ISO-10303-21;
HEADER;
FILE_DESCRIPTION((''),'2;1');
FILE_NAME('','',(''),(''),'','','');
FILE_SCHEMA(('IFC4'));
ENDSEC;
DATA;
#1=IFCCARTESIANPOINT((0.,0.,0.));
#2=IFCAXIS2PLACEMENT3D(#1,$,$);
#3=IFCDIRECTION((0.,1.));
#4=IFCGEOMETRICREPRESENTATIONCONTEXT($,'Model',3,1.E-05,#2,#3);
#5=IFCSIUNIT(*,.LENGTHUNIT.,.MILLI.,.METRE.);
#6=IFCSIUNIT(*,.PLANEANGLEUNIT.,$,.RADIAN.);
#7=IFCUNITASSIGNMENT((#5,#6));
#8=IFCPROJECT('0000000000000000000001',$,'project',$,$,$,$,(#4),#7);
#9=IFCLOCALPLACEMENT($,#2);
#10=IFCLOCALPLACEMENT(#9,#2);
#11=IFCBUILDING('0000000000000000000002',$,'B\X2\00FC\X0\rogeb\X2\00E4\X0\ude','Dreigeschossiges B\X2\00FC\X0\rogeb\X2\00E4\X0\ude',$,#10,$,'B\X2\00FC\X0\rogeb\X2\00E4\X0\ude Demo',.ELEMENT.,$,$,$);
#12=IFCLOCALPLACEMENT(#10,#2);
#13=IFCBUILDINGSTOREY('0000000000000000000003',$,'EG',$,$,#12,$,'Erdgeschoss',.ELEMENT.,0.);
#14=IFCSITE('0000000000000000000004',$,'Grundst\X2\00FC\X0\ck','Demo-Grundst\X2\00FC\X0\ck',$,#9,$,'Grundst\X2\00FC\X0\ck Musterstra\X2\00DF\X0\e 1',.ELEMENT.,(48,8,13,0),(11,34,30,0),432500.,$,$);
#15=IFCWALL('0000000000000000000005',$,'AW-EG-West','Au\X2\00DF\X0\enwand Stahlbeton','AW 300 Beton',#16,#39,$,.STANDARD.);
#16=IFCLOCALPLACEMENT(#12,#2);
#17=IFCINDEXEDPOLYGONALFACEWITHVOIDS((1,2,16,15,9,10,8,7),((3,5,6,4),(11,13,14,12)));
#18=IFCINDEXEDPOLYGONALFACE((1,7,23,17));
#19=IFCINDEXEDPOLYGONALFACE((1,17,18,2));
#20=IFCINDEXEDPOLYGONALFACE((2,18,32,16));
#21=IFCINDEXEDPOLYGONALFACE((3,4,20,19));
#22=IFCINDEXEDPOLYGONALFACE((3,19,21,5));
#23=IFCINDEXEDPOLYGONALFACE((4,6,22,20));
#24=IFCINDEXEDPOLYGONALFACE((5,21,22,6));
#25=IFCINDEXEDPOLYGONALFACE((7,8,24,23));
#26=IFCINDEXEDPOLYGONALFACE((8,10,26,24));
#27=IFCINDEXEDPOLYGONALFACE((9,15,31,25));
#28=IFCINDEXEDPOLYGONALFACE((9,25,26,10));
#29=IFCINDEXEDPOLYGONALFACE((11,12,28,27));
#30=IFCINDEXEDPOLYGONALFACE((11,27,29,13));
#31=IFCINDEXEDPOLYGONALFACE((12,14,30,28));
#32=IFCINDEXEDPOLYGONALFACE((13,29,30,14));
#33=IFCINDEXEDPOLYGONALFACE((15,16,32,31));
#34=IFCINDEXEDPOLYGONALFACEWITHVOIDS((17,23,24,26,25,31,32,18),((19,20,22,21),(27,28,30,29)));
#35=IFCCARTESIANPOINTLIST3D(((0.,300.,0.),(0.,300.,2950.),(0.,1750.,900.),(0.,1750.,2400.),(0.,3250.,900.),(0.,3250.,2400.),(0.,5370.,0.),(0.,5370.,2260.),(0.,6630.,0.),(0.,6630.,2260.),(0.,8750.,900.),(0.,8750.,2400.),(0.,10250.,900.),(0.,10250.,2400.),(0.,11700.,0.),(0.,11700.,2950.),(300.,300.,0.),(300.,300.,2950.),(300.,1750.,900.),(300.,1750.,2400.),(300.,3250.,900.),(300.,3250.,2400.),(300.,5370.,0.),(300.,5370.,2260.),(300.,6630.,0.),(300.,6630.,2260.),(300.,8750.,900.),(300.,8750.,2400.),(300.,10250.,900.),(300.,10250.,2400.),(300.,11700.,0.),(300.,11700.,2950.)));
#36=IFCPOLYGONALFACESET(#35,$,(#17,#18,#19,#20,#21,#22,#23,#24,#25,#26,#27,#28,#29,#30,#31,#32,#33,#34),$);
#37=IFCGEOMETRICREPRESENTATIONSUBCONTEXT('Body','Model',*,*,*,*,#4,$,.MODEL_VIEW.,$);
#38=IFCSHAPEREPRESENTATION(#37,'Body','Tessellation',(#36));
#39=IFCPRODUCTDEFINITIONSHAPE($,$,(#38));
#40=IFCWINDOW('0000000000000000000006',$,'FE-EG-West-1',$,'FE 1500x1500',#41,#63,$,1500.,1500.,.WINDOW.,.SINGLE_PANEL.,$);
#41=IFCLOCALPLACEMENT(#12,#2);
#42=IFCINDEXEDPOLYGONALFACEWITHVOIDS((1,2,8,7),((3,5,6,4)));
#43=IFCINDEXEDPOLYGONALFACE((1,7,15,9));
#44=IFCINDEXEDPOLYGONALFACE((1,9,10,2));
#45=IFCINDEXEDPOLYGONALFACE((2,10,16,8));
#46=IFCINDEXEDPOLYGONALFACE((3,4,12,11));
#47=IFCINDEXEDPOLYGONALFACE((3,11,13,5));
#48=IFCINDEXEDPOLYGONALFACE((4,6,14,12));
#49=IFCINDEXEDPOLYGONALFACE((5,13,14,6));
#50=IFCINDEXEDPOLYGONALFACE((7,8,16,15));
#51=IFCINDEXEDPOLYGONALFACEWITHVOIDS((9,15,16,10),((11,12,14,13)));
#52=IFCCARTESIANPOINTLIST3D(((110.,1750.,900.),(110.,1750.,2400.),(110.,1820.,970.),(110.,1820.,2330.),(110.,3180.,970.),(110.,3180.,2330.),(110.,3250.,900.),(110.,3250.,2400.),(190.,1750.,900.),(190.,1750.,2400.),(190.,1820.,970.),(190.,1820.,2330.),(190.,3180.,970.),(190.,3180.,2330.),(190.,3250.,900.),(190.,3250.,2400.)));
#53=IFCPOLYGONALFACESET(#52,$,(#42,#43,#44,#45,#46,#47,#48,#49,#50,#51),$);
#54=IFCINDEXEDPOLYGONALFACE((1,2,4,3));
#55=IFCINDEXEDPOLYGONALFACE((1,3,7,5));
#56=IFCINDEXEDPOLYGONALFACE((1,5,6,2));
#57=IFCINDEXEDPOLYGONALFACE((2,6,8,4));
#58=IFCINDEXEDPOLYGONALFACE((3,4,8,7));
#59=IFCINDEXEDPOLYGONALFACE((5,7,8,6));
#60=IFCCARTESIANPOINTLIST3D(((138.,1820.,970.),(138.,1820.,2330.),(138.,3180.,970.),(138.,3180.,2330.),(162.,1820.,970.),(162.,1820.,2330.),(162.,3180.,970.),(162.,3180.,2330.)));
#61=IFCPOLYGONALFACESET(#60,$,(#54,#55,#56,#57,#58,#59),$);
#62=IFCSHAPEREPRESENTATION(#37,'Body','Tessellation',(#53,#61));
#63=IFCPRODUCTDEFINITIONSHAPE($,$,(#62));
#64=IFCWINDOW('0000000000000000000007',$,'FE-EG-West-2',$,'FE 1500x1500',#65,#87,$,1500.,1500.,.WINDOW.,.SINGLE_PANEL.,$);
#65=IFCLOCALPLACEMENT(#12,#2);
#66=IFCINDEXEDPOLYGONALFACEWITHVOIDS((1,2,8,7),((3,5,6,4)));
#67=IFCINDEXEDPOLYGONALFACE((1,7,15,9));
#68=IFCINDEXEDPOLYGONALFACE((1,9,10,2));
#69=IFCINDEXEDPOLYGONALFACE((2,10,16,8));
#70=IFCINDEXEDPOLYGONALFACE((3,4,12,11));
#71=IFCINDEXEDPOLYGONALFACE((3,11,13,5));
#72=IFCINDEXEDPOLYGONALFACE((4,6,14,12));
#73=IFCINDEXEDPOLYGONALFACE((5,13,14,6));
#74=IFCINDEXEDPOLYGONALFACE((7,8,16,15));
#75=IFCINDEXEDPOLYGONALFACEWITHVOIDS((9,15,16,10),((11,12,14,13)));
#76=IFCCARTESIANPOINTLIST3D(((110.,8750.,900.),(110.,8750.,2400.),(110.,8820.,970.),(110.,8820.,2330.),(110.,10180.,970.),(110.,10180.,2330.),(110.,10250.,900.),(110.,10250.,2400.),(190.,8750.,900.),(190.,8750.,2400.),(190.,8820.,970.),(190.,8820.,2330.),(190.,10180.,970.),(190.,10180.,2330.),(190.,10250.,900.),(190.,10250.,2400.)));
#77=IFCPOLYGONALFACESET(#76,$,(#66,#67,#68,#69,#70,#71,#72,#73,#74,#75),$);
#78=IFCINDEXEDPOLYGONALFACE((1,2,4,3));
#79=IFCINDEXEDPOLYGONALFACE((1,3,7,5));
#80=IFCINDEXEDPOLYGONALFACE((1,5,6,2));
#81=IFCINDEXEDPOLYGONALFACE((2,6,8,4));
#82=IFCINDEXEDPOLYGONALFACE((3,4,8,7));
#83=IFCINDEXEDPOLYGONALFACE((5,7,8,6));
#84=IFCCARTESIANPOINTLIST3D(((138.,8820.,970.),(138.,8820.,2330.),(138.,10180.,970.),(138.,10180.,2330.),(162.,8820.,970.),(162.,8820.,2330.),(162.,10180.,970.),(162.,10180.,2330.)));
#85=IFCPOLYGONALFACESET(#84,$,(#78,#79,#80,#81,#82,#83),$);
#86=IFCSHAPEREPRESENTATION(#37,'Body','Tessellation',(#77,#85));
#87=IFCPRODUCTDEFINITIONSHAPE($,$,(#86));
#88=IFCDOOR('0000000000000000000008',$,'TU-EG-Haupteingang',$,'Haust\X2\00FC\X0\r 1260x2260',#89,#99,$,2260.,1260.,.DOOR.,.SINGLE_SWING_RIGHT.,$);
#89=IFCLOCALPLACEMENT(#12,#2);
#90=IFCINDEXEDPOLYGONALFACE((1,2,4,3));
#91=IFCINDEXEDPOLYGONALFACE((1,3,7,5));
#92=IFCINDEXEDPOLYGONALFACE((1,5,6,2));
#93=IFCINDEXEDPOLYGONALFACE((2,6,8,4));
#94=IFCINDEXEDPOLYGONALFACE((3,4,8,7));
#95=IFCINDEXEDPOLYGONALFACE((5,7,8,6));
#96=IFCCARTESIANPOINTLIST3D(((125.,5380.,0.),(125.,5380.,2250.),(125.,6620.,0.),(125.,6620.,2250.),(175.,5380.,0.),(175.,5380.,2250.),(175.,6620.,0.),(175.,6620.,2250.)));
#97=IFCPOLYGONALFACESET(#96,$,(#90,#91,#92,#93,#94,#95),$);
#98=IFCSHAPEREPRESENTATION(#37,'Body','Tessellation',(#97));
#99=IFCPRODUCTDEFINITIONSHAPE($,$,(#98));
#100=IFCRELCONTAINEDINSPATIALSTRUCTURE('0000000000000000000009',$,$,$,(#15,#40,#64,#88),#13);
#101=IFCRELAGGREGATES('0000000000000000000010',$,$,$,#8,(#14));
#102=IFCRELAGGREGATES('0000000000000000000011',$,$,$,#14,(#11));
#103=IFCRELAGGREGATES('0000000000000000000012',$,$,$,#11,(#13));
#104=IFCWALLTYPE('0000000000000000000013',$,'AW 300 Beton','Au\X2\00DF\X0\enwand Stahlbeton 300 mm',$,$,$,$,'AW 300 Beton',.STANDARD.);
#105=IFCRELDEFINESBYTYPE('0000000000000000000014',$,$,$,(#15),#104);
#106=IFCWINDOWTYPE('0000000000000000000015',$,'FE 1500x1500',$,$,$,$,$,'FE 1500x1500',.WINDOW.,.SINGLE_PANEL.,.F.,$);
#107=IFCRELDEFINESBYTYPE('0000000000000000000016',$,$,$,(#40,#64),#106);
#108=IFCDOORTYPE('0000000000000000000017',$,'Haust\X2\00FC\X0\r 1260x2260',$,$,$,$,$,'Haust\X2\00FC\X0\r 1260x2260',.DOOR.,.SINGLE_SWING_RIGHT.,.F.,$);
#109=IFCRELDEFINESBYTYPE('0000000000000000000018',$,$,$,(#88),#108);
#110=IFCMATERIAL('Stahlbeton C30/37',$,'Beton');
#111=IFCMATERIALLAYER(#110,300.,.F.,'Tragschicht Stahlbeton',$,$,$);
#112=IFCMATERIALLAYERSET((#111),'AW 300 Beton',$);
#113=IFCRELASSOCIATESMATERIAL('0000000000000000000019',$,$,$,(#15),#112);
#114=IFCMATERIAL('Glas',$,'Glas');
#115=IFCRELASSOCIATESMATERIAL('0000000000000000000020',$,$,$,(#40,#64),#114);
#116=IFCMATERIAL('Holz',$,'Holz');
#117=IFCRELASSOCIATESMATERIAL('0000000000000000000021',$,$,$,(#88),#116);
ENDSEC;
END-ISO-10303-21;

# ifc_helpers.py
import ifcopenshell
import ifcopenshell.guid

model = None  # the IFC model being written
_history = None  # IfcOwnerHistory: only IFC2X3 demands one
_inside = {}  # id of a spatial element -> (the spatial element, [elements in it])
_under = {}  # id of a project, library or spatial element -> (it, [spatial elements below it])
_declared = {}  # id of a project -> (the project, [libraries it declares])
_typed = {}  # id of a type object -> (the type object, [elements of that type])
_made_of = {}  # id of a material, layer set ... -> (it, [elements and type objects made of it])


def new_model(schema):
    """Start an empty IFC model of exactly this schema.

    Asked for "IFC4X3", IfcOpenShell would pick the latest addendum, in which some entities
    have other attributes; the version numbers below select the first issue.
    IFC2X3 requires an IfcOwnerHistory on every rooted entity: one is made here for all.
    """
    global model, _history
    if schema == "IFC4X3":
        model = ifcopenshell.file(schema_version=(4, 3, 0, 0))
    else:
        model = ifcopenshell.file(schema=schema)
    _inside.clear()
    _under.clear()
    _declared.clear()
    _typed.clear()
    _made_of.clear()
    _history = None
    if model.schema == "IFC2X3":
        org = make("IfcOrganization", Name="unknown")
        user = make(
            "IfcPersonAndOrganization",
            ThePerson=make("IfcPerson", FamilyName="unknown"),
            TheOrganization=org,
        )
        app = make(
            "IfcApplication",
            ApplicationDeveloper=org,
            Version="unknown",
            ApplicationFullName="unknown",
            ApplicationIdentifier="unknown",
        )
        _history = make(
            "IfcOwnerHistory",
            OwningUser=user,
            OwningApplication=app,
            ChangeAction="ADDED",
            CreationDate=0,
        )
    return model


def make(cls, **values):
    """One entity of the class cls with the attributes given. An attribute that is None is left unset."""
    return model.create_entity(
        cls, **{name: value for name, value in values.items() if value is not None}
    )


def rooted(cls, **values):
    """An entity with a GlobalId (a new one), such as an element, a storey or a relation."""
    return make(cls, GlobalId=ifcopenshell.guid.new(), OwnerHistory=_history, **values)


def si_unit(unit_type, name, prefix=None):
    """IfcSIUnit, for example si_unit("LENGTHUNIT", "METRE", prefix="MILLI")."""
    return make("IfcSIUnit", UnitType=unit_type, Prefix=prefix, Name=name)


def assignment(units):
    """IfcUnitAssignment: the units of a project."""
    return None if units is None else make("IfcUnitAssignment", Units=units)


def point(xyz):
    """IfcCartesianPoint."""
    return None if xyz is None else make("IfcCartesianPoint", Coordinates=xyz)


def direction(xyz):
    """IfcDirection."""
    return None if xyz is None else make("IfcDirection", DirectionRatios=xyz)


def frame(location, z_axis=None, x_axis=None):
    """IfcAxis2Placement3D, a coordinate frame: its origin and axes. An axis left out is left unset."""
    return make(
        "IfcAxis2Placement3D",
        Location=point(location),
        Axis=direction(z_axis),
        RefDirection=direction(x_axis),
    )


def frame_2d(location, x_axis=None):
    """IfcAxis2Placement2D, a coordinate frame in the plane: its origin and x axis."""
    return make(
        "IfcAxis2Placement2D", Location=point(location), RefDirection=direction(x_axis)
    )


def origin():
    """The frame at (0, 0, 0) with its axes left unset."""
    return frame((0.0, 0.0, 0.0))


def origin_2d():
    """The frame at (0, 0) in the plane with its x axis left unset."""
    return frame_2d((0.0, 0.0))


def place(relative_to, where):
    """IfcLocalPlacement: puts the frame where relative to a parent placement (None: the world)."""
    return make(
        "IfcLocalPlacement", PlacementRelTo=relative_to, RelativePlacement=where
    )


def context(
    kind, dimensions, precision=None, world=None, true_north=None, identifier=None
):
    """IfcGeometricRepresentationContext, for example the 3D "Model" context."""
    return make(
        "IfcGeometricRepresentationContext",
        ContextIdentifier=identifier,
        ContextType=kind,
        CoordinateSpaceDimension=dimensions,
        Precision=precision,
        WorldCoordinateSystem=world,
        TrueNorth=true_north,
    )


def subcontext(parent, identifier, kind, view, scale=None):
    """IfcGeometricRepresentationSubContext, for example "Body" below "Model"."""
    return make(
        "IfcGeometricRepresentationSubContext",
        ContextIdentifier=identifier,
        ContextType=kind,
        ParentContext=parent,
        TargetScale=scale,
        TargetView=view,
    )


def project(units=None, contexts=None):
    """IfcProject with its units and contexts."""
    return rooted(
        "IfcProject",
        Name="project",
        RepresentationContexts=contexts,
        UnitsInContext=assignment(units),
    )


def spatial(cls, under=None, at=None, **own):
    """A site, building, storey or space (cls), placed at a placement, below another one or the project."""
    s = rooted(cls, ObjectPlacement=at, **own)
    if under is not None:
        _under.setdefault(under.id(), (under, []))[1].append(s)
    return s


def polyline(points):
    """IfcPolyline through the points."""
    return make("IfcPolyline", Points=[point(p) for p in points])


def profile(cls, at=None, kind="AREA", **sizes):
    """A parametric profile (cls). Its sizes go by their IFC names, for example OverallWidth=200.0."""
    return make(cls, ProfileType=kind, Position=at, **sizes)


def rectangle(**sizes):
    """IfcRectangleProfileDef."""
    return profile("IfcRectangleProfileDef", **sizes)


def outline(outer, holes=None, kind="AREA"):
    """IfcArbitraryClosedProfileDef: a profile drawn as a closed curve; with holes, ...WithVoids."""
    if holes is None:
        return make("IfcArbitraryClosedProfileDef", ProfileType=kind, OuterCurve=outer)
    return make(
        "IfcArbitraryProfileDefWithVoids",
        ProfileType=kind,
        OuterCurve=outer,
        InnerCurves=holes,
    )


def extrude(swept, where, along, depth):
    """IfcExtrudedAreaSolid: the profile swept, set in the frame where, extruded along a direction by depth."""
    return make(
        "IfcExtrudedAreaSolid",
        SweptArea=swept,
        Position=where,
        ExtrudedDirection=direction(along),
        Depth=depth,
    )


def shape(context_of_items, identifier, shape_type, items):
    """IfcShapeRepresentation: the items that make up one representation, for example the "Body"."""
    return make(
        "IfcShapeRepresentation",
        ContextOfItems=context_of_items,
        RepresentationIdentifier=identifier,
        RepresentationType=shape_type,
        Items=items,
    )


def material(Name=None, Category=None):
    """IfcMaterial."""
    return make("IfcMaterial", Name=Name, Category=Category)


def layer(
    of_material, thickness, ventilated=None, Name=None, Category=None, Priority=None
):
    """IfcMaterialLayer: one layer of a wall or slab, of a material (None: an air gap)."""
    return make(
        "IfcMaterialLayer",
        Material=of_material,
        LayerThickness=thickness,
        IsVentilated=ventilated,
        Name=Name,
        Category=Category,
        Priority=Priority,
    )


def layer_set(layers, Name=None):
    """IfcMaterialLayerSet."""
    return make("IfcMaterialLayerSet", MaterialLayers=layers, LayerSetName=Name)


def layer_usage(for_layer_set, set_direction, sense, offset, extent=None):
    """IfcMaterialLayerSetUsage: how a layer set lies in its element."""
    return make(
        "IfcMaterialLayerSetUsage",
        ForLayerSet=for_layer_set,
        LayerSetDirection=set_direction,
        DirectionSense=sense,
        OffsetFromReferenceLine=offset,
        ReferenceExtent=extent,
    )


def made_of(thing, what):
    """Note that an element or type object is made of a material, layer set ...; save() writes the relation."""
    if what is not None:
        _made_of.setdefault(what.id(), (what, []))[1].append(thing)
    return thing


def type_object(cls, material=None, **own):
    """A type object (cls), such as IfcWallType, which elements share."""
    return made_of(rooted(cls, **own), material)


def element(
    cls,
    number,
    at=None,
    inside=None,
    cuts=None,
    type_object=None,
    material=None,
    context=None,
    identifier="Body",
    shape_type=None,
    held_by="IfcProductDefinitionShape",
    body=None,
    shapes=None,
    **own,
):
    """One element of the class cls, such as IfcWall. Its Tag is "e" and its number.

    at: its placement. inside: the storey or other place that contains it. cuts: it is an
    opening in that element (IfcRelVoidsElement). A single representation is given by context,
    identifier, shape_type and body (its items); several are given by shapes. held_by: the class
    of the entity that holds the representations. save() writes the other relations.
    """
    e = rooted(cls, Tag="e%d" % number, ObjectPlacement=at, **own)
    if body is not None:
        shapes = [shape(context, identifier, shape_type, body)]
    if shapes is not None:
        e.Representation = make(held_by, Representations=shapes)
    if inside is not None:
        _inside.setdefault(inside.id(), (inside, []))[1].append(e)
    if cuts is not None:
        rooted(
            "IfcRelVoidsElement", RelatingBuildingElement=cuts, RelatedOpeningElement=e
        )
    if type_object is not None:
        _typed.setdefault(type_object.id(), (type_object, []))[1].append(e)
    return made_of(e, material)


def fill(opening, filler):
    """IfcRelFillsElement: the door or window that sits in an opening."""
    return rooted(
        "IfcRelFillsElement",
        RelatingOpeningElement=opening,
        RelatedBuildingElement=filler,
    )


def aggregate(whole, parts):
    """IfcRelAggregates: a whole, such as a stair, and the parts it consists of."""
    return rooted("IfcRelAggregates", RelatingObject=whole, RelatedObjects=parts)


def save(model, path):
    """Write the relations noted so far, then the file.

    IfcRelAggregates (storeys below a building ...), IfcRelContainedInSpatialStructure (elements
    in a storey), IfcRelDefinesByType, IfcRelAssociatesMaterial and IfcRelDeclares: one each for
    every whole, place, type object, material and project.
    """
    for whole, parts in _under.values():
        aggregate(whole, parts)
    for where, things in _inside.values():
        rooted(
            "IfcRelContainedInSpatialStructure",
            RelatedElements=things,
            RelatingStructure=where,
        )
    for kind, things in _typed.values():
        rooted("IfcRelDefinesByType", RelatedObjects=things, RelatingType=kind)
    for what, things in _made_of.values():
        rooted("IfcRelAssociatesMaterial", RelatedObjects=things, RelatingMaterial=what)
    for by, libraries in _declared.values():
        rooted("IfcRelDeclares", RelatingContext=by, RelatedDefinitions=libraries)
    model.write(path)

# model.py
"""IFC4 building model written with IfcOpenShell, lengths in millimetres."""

from ifc_helpers import new_model, si_unit, direction, frame, frame_2d, origin, origin_2d, place, context, subcontext, project, spatial, polyline, rectangle, outline, extrude, material, layer, layer_set, layer_usage, type_object, element, fill, save


model = new_model("IFC4")

# Units and contexts
model_context = context("Model", 3, precision=1e-05, world=origin(), true_north=direction((0.0, 1.0)))
body_context = subcontext(model_context, "Body", "Model", "MODEL_VIEW")
ifc_project = project(units=[si_unit("LENGTHUNIT", "METRE", prefix="MILLI"), si_unit("PLANEANGLEUNIT", "RADIAN")], contexts=[model_context])

# Site, building, storey
site_placement = place(None, origin())
site = spatial("IfcSite", under=ifc_project, at=site_placement, Name="Grundstück", Description="Demo-Grundstück", LongName="Grundstück Musterstraße 1", CompositionType="ELEMENT", RefLatitude=(48, 8, 13, 0), RefLongitude=(11, 34, 30, 0), RefElevation=432500.0)
building_placement = place(site_placement, origin())
building = spatial("IfcBuilding", under=site, at=building_placement, Name="Bürogebäude", Description="Dreigeschossiges Bürogebäude", LongName="Bürogebäude Demo", CompositionType="ELEMENT")
storey_placement = place(building_placement, origin())
storey = spatial("IfcBuildingStorey", under=building, at=storey_placement, Name="EG", LongName="Erdgeschoss", CompositionType="ELEMENT", Elevation=0.0)

# Shared definitions
ifc_material_1 = material(Name="Stahlbeton C30/37", Category="Beton")

# Shared definitions
ifc_layer = layer(ifc_material_1, 300.0, ventilated=False, Name="Tragschicht Stahlbeton")
ifc_layer_set = layer_set([ifc_layer], Name="AW 300 Beton")
ifc_layer_usage = layer_usage(ifc_layer_set, "AXIS2", "POSITIVE", -150.0)
wall_type = type_object("IfcWallType", Name="AW 300 Beton", Description="Außenwand Stahlbeton 300 mm", ElementType="AW 300 Beton", PredefinedType="STANDARD")
ifc_material_2 = material(Name="Glas", Category="Glas")
window_type = type_object("IfcWindowType", Name="FE 1500x1500", ElementType="FE 1500x1500", ParameterTakesPrecedence=False, PartitioningType="SINGLE_PANEL", PredefinedType="WINDOW")

# Wall, openings, windows, door
wall_1_placement = place(storey_placement, frame((150.0, 300.0, 0.0), z_axis=(0.0, 0.0, 1.0), x_axis=(0.0, 1.0, 0.0)))
wall_1 = element("IfcWall", 1, at=wall_1_placement, inside=storey, type_object=wall_type, material=ifc_layer_usage, Name="AW-EG-West", Description="Außenwand Stahlbeton", ObjectType="AW 300 Beton", PredefinedType="STANDARD", context=body_context, shape_type="SweptSolid", body=[
    extrude(rectangle(XDim=11400.0, YDim=300.0, at=frame_2d((5700.0, 0.0))), origin(), (0.0, 0.0, 1.0), 2950.0),
])
opening_1_placement = place(wall_1_placement, frame((2200.0, 0.0, 900.0)))
opening_1 = element("IfcOpeningElement", 2, at=opening_1_placement, cuts=wall_1, PredefinedType="OPENING", context=body_context, shape_type="SweptSolid", body=[
    extrude(rectangle(XDim=1500.0, YDim=340.0, at=origin_2d()), origin(), (0.0, 0.0, 1.0), 1500.0),
])
opening_2_placement = place(wall_1_placement, frame((9200.0, 0.0, 900.0)))
opening_2 = element("IfcOpeningElement", 3, at=opening_2_placement, cuts=wall_1, PredefinedType="OPENING", context=body_context, shape_type="SweptSolid", body=[
    extrude(rectangle(XDim=1500.0, YDim=340.0, at=origin_2d()), origin(), (0.0, 0.0, 1.0), 1500.0),
])
opening_3_placement = place(wall_1_placement, frame((5700.0, 0.0, 0.0)))
opening_3 = element("IfcOpeningElement", 4, at=opening_3_placement, cuts=wall_1, PredefinedType="OPENING", context=body_context, shape_type="SweptSolid", body=[
    extrude(rectangle(XDim=1260.0, YDim=340.0, at=origin_2d()), frame((0.0, 0.0, -20.0)), (0.0, 0.0, 1.0), 2280.0),
])
window_1_placement = place(opening_1_placement, origin())
window_1 = element("IfcWindow", 5, at=window_1_placement, inside=storey, type_object=window_type, material=ifc_material_2, Name="FE-EG-West-1", ObjectType="FE 1500x1500", OverallHeight=1500.0, OverallWidth=1500.0, PartitioningType="SINGLE_PANEL", PredefinedType="WINDOW", context=body_context, shape_type="SweptSolid", body=[
    extrude(outline(polyline([(-750.0, 0.0), (750.0, 0.0), (750.0, 1500.0), (-750.0, 1500.0), (-750.0, 0.0)]), holes=[polyline([(-680.0, 70.0), (680.0, 70.0), (680.0, 1430.0), (-680.0, 1430.0), (-680.0, 70.0)])]), frame((0.0, 40.0, 0.0), z_axis=(0.0, -1.0, 0.0), x_axis=(1.0, 0.0, 0.0)), (0.0, 0.0, 1.0), 80.0),
    extrude(rectangle(XDim=1360.0, YDim=24.0, at=origin_2d()), frame((0.0, 0.0, 70.0)), (0.0, 0.0, 1.0), 1360.0),
])
fill(opening_1, window_1)
window_2_placement = place(opening_2_placement, origin())
window_2 = element("IfcWindow", 6, at=window_2_placement, inside=storey, type_object=window_type, material=ifc_material_2, Name="FE-EG-West-2", ObjectType="FE 1500x1500", OverallHeight=1500.0, OverallWidth=1500.0, PartitioningType="SINGLE_PANEL", PredefinedType="WINDOW", context=body_context, shape_type="SweptSolid", body=[
    extrude(outline(polyline([(-750.0, 0.0), (750.0, 0.0), (750.0, 1500.0), (-750.0, 1500.0), (-750.0, 0.0)]), holes=[polyline([(-680.0, 70.0), (680.0, 70.0), (680.0, 1430.0), (-680.0, 1430.0), (-680.0, 70.0)])]), frame((0.0, 40.0, 0.0), z_axis=(0.0, -1.0, 0.0), x_axis=(1.0, 0.0, 0.0)), (0.0, 0.0, 1.0), 80.0),
    extrude(rectangle(XDim=1360.0, YDim=24.0, at=origin_2d()), frame((0.0, 0.0, 70.0)), (0.0, 0.0, 1.0), 1360.0),
])
fill(opening_2, window_2)
ifc_material_3 = material(Name="Holz", Category="Holz")
door_type = type_object("IfcDoorType", Name="Haustür 1260x2260", ElementType="Haustür 1260x2260", OperationType="SINGLE_SWING_RIGHT", ParameterTakesPrecedence=False, PredefinedType="DOOR")
door_placement = place(opening_3_placement, origin())
door = element("IfcDoor", 7, at=door_placement, inside=storey, type_object=door_type, material=ifc_material_3, Name="TU-EG-Haupteingang", ObjectType="Haustür 1260x2260", OperationType="SINGLE_SWING_RIGHT", OverallHeight=2260.0, OverallWidth=1260.0, PredefinedType="DOOR", context=body_context, shape_type="SweptSolid", body=[
    extrude(rectangle(XDim=1240.0, YDim=50.0, at=origin_2d()), origin(), (0.0, 0.0, 1.0), 2250.0),
])
fill(opening_3, door)

save(model, "model.ifc")
